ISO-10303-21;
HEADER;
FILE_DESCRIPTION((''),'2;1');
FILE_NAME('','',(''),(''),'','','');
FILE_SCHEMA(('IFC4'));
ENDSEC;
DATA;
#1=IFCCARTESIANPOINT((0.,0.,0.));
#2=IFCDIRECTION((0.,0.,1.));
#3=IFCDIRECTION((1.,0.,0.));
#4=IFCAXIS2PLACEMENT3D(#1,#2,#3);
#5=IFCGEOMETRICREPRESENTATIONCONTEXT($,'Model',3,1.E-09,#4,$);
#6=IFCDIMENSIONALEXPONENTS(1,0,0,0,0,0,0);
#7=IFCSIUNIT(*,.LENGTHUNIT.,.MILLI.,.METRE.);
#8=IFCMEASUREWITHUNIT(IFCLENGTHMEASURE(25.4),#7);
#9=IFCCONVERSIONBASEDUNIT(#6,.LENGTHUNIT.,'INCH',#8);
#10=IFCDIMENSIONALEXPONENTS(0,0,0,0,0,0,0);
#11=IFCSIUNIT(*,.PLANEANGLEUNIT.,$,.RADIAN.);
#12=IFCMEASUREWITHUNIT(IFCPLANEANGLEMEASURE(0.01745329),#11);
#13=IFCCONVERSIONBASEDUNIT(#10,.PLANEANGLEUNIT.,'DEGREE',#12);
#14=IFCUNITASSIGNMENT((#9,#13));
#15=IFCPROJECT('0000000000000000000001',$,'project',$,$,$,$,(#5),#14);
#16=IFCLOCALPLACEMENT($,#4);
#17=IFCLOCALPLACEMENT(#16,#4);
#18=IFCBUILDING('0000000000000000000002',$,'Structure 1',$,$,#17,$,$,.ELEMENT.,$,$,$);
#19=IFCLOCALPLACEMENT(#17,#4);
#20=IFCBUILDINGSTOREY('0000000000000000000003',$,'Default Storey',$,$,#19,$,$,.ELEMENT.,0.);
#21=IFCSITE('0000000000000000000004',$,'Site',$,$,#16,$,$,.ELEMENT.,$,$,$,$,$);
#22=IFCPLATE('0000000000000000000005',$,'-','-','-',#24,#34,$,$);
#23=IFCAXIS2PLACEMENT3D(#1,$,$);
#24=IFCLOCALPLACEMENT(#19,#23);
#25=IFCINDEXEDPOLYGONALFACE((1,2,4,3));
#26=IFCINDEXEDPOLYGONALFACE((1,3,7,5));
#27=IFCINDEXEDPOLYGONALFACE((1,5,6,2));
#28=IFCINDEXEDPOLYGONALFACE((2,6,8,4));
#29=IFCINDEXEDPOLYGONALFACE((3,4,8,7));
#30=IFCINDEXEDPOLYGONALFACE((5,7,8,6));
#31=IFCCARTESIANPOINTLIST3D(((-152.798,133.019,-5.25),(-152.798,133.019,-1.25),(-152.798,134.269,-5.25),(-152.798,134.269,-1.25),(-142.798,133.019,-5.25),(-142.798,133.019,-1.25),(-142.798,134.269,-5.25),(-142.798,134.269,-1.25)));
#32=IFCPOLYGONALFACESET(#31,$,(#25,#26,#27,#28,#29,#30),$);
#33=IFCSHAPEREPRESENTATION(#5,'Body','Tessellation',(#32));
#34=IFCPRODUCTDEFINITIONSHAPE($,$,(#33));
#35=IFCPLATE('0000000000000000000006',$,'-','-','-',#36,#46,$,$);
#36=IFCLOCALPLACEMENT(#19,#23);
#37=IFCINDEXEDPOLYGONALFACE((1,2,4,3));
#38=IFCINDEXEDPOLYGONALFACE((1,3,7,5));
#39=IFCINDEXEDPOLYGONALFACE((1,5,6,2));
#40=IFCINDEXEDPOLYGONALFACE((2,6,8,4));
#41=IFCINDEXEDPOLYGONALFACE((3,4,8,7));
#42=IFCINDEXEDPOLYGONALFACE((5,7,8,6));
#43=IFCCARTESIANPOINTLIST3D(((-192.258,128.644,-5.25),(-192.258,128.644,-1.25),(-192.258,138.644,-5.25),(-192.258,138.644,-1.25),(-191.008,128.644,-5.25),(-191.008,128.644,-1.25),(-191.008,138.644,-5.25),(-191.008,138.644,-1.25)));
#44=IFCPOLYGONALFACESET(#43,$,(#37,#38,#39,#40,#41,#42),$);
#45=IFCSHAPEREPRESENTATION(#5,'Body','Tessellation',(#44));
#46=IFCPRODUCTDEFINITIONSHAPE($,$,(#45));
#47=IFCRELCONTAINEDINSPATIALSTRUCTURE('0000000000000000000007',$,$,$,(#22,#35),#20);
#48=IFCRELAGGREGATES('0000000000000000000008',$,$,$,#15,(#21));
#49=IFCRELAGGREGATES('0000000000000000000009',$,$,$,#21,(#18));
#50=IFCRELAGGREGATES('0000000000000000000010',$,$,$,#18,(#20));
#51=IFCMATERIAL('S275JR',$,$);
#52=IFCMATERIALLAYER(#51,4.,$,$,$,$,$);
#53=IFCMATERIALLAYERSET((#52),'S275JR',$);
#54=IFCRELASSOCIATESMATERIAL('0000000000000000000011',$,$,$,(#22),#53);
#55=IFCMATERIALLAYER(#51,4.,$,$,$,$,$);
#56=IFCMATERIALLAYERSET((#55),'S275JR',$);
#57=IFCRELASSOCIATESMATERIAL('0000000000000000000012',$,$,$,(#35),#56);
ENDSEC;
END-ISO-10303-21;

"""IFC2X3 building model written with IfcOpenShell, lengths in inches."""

from ifc_helpers import new_model, entity, si_unit, converted_unit, frame, origin_with_axes, place, context, project, spatial, polyline, outline, extrude, material, layer, layer_set, element, save


model = new_model("IFC2X3")

# Units and contexts
model_context = context("Model", 3, precision=1e-09, world=origin_with_axes())
ifc_project = project(units=[converted_unit("LENGTHUNIT", "INCH", entity("IfcLengthMeasure", 25.4), si_unit("LENGTHUNIT", "METRE", prefix="MILLI"), dimensions=[1, 0, 0, 0, 0, 0, 0]), converted_unit("PLANEANGLEUNIT", "DEGREE", entity("IfcPlaneAngleMeasure", 0.01745329), si_unit("PLANEANGLEUNIT", "RADIAN"), dimensions=[0, 0, 0, 0, 0, 0, 0])], contexts=[model_context])

# Site, building, storey
site_placement = place(None, origin_with_axes())
site = spatial("IfcSite", under=ifc_project, at=site_placement, Name="Site", CompositionType="ELEMENT")
building_placement = place(site_placement, origin_with_axes())
building = spatial("IfcBuilding", under=site, at=building_placement, Name="Structure 1", CompositionType="ELEMENT")
storey_placement = place(building_placement, origin_with_axes())
storey = spatial("IfcBuildingStorey", under=building, at=storey_placement, Name="Default Storey", CompositionType="ELEMENT", Elevation=0.0)

# Plates
ifc_material_1 = material(Name="S275JR")
ifc_layer_1 = layer(ifc_material_1, 4.0)
ifc_layer_set_1 = layer_set([ifc_layer_1], Name="S275JR")
plate_1_placement = place(None, frame((-147.798, 133.644, -5.25), z_axis=(0.0, 0.0, 1.0), x_axis=(0.0, -1.0, 0.0)))
element("IfcPlate", 1, at=plate_1_placement, inside=storey, material=ifc_layer_set_1, Name="-", Description="-", ObjectType="-", context=model_context, shape_type="SweptSolid", body=[
    extrude(outline(polyline([(-0.625, -5.0), (0.625, -5.0), (0.625, 5.0), (-0.625, 5.0), (-0.625, -5.0)])), origin_with_axes(), (0.0, 0.0, 1.0), 4.0),
])
ifc_layer_2 = layer(ifc_material_1, 4.0)
ifc_layer_set_2 = layer_set([ifc_layer_2], Name="S275JR")
plate_2_placement = place(None, frame((-191.633, 133.644, -5.25), z_axis=(0.0, 0.0, 1.0), x_axis=(1.0, 0.0, 0.0)))
element("IfcPlate", 2, at=plate_2_placement, inside=storey, material=ifc_layer_set_2, Name="-", Description="-", ObjectType="-", context=model_context, shape_type="SweptSolid", body=[
    extrude(outline(polyline([(-0.625, -5.0), (0.625, -5.0), (0.625, 5.0), (-0.625, 5.0), (-0.625, -5.0)])), origin_with_axes(), (0.0, 0.0, 1.0), 4.0),
])

save(model, "model.ifc")
